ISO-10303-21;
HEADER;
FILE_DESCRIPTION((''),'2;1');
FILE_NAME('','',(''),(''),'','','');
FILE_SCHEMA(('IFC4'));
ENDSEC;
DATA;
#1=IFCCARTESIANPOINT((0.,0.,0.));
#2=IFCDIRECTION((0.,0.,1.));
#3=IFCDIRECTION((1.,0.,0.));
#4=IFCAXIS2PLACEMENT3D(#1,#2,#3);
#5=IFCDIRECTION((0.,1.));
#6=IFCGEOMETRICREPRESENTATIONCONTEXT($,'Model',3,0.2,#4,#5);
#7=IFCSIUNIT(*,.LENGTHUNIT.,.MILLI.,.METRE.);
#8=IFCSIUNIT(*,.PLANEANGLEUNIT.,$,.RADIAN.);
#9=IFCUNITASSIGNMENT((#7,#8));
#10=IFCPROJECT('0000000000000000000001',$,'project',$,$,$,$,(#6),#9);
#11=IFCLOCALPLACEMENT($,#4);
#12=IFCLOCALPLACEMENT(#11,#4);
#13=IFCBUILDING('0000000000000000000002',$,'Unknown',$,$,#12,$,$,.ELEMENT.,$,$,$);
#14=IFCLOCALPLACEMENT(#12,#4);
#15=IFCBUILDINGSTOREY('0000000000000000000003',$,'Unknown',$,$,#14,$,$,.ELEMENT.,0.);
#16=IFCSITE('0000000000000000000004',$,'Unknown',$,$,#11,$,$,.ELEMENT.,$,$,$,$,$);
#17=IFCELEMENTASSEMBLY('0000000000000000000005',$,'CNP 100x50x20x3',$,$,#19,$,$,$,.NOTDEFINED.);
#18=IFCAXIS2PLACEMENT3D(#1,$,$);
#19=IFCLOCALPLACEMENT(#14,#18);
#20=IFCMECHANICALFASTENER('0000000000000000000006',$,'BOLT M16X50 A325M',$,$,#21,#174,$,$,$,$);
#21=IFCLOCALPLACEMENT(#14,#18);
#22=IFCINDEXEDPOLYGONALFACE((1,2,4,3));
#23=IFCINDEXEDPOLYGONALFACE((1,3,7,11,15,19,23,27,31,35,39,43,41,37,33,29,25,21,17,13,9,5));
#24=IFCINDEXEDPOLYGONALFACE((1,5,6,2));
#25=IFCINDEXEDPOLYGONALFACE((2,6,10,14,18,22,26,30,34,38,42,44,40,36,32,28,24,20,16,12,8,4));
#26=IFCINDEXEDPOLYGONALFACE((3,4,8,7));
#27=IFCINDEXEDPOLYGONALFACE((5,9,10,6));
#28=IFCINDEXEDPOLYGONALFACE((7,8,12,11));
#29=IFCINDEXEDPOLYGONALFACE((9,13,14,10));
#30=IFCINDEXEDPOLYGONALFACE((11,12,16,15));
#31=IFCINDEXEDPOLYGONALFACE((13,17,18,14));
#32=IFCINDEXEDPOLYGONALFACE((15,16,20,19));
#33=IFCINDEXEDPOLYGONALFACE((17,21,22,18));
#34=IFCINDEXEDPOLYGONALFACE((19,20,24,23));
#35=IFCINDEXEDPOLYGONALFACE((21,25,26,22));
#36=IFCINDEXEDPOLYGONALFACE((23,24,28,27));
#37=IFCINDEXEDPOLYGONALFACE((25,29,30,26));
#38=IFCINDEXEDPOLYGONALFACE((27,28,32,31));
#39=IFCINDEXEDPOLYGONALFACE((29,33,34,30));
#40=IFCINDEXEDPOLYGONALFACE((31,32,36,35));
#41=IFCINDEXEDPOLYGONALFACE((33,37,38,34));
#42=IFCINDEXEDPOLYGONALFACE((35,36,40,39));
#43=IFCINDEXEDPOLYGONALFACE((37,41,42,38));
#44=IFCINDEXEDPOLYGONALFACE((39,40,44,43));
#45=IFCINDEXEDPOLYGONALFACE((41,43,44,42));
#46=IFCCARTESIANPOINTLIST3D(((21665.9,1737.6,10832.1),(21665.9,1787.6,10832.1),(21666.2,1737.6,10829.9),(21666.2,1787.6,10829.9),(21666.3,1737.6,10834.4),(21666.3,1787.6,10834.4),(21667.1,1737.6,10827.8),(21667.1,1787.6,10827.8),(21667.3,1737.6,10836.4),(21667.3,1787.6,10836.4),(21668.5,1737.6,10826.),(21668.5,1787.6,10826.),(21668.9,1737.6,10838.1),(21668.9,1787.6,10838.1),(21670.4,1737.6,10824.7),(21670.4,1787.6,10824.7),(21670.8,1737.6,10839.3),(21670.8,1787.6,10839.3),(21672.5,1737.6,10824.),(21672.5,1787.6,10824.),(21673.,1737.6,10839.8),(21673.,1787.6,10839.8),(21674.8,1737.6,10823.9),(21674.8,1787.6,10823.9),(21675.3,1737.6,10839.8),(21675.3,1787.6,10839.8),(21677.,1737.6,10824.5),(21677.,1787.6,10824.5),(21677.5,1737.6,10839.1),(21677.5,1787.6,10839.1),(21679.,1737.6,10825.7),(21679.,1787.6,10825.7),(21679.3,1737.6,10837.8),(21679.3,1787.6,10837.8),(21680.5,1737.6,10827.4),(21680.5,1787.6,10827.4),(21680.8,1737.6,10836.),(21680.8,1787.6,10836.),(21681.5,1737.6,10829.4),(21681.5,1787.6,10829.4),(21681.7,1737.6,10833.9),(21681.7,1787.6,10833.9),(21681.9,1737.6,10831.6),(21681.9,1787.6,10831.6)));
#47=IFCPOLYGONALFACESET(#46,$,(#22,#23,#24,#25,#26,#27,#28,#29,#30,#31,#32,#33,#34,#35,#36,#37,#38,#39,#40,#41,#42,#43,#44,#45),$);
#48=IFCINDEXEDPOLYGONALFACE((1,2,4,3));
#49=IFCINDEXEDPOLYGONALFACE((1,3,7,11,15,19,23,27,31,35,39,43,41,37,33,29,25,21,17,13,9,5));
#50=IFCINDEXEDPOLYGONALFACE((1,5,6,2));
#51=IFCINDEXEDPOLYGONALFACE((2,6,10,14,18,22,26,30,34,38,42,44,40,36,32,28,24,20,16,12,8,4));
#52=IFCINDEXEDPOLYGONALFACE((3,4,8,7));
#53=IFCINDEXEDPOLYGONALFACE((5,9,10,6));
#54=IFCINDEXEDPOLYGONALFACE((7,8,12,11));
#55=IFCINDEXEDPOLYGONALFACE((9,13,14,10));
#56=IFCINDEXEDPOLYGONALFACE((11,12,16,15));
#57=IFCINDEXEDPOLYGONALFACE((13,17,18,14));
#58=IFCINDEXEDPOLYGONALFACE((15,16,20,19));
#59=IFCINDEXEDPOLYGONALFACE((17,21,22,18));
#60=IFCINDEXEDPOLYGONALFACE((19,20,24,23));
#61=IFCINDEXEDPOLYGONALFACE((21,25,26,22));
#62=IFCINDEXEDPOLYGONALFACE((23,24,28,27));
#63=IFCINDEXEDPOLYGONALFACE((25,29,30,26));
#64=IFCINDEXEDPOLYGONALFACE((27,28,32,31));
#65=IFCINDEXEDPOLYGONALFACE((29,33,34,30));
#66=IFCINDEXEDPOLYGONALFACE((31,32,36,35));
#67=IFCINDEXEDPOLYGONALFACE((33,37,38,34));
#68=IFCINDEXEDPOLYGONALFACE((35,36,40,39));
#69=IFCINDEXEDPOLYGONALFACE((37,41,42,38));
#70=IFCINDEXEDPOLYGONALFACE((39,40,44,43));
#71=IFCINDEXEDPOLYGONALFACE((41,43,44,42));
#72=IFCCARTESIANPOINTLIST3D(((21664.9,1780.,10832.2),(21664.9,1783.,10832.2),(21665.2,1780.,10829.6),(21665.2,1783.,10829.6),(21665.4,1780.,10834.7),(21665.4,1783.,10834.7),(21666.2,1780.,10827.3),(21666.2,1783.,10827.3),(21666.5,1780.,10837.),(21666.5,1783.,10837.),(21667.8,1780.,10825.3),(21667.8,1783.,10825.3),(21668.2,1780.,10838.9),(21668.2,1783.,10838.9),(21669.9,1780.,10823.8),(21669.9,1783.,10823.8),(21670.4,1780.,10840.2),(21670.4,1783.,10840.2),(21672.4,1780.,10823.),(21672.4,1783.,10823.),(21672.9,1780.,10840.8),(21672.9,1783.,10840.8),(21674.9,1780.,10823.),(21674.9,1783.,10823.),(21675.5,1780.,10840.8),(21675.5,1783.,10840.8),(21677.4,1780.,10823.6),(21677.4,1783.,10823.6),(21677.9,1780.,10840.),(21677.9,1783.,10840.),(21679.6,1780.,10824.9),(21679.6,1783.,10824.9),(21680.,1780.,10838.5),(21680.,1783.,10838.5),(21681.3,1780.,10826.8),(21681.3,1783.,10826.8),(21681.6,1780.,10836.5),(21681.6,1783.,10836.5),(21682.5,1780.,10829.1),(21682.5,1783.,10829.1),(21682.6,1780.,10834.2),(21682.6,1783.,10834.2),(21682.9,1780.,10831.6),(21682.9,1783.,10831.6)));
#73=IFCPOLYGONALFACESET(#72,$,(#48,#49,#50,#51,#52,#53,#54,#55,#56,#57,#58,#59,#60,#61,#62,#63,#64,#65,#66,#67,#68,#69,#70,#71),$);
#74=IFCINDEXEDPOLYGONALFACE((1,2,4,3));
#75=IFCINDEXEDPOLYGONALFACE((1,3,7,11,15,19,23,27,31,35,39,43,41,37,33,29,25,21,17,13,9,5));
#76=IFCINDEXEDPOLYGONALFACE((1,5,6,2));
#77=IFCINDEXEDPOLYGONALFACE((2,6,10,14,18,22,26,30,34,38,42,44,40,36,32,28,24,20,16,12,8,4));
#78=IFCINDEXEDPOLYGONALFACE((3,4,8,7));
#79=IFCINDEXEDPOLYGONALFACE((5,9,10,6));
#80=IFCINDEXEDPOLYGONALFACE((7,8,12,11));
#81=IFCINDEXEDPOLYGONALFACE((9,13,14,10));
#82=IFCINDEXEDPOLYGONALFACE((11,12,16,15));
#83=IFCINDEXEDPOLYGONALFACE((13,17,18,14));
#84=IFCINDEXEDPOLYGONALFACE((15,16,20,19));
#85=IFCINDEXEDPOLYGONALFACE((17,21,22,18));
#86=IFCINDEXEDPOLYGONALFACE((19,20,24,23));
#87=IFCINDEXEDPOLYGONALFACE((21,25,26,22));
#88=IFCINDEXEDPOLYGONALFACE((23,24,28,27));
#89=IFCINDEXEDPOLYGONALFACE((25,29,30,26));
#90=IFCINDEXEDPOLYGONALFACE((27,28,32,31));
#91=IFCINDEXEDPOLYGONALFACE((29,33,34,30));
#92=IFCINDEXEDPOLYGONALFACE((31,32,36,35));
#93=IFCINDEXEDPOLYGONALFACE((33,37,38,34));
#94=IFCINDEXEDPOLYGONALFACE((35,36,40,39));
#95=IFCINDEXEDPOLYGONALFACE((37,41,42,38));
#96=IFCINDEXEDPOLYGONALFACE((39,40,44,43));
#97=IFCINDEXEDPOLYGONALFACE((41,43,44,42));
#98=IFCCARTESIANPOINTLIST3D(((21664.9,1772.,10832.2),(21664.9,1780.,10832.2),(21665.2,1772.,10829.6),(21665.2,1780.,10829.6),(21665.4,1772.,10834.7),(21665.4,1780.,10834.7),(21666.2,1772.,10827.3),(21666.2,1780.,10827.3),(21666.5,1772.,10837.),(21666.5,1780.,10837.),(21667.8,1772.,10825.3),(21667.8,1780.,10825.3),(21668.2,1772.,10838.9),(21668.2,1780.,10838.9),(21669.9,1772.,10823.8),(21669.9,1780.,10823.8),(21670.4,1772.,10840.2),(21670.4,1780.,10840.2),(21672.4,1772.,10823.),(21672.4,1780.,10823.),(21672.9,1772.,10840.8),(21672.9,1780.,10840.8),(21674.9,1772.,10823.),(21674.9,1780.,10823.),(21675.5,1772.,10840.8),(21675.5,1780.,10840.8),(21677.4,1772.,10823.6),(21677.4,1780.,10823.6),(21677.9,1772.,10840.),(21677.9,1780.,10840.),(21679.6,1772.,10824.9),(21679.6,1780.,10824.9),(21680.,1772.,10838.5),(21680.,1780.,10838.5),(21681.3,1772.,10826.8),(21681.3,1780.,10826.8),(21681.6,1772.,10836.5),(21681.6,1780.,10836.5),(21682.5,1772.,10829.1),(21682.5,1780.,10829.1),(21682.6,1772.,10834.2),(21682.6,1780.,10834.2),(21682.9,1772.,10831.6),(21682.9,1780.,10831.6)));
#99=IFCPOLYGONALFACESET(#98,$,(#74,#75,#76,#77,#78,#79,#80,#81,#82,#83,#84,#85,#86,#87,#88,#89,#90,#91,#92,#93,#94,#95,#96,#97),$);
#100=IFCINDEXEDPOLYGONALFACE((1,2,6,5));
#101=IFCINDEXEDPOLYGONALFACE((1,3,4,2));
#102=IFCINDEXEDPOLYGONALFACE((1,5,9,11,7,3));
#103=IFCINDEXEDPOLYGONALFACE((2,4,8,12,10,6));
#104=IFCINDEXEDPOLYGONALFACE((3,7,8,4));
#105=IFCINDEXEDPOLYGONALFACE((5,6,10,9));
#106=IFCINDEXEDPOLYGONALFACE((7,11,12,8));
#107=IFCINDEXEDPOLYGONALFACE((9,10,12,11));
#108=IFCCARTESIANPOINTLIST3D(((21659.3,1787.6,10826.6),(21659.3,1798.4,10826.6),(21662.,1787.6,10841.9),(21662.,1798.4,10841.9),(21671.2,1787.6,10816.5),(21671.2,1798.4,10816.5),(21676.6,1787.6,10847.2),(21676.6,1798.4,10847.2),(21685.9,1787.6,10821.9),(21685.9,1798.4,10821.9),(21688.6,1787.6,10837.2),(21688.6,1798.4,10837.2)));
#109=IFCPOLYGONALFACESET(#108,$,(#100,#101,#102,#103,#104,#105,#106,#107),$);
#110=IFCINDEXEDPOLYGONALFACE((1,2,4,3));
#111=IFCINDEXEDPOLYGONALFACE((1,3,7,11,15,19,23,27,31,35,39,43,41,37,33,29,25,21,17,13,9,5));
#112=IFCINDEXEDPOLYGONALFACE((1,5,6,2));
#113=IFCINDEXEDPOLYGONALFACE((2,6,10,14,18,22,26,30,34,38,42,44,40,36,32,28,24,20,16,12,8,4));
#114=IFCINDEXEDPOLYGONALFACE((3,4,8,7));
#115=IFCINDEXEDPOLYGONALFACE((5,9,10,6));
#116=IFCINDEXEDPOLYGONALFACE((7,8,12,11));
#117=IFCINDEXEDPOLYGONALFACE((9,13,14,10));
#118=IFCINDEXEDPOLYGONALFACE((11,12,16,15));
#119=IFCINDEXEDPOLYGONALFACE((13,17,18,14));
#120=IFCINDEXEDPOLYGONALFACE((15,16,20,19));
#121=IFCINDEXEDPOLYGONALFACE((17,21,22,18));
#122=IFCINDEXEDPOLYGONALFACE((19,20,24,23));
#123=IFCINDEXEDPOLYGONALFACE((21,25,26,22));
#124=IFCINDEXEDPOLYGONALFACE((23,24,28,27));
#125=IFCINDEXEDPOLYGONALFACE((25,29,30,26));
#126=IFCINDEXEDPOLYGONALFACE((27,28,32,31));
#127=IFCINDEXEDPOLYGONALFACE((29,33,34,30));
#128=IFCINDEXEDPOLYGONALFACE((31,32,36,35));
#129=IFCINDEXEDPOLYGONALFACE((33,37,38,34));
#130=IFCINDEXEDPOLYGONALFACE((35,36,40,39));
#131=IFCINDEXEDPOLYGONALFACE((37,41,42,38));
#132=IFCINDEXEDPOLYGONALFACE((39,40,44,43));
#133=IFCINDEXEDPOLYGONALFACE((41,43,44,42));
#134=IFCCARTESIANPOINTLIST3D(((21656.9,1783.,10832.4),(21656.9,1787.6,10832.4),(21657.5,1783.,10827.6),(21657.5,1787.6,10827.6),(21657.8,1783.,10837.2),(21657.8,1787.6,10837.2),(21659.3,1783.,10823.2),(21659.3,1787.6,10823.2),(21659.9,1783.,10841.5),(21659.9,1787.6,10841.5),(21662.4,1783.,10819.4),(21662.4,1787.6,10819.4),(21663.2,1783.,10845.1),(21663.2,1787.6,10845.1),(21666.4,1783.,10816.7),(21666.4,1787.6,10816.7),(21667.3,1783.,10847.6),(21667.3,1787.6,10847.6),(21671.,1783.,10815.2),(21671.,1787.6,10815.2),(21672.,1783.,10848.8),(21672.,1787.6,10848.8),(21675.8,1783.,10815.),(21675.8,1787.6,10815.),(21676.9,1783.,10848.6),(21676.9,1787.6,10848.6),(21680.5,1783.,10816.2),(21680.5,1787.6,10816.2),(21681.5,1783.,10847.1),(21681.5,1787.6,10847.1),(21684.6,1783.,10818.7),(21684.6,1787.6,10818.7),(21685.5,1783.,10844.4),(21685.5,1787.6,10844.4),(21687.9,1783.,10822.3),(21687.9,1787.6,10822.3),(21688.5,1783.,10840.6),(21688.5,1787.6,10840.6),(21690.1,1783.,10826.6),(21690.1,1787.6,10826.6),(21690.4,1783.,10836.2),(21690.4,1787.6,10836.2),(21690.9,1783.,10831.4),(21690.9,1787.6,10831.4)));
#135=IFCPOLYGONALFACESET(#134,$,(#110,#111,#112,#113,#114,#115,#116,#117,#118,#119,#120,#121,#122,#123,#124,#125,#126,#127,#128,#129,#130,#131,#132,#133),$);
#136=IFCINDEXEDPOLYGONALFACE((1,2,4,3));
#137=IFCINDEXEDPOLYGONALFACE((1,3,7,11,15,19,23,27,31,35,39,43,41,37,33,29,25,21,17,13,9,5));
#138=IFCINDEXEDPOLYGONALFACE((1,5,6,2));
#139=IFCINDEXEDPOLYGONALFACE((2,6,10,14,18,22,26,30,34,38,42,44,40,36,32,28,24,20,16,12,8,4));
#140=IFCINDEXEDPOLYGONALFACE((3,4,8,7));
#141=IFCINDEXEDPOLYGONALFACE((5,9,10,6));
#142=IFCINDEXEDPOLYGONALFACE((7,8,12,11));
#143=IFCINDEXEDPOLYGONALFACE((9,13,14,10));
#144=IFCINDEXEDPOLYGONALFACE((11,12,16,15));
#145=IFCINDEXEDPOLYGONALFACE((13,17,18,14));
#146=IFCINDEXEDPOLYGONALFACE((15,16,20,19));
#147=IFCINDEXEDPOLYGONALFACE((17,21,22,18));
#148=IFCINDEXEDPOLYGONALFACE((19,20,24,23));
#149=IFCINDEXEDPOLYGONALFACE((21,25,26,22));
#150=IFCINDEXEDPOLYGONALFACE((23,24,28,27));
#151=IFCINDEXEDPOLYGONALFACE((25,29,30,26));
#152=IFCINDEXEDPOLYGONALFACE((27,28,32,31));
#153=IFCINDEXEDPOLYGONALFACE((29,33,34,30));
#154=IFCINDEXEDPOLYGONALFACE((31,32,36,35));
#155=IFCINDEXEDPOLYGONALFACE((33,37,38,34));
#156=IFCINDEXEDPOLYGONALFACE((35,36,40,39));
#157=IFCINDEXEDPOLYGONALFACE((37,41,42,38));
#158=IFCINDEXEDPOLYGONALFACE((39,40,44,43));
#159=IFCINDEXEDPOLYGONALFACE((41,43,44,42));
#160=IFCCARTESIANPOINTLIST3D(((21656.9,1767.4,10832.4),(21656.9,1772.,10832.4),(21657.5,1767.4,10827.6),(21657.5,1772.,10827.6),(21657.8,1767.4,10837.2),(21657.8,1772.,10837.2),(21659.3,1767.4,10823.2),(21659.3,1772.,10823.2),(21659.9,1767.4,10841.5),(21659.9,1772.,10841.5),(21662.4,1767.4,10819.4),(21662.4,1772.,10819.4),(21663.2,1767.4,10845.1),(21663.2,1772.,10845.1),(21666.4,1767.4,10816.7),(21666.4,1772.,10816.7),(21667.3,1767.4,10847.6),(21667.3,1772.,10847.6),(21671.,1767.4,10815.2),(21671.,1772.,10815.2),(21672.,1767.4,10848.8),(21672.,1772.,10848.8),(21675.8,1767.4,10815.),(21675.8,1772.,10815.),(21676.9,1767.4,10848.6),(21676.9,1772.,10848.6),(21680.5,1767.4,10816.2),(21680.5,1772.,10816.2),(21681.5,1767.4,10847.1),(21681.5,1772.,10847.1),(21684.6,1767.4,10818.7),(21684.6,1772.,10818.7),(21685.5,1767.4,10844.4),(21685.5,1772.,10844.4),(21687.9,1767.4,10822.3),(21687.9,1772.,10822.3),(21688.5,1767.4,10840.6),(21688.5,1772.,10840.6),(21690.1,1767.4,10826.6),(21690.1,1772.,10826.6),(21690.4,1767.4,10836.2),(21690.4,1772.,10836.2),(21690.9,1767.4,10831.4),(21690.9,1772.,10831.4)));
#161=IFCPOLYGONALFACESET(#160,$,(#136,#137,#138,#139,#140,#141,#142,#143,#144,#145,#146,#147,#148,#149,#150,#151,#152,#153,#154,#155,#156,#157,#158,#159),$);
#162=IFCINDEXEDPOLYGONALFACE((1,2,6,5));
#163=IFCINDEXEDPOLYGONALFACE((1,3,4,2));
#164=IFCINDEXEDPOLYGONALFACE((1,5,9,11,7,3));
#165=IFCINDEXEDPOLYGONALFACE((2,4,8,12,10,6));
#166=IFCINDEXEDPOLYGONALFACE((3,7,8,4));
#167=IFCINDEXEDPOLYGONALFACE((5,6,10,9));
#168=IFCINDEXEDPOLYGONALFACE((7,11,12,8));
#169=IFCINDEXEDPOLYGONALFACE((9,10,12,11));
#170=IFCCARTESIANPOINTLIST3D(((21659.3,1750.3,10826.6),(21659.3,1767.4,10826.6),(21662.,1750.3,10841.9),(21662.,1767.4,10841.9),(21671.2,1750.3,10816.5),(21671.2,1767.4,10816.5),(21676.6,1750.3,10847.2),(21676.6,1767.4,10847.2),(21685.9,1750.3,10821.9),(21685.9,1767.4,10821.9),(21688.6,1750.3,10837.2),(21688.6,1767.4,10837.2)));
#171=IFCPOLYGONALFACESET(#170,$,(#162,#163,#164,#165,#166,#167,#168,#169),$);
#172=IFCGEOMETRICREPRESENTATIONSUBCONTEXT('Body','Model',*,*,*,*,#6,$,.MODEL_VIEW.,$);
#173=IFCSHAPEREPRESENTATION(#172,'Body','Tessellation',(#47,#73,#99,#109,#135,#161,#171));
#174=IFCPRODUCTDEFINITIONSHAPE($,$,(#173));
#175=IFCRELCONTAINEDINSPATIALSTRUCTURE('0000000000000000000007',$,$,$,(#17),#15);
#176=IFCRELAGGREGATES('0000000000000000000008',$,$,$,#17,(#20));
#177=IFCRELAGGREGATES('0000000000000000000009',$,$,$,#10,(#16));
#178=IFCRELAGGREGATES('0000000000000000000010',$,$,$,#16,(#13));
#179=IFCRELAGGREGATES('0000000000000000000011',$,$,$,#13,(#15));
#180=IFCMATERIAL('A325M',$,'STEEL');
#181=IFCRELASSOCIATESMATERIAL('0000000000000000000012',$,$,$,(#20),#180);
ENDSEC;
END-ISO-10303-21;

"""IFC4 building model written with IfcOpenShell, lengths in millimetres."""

from ifc_helpers import new_model, si_unit, direction, frame, origin_with_axes, place, context, subcontext, project, spatial, line, arc, indexed_curve, outline, extrude, source, transform, mapped, material, element, aggregate, save


model = new_model("IFC4")

# Units and contexts
model_context = context("Model", 3, precision=0.2, world=origin_with_axes(), true_north=direction((0.0, 1.0)))
body_context = subcontext(model_context, "Body", "Model", "MODEL_VIEW")
ifc_project = project(units=[si_unit("LENGTHUNIT", "METRE", prefix="MILLI"), si_unit("PLANEANGLEUNIT", "RADIAN")], contexts=[model_context])

# Site, building, storey
site_placement = place(None, origin_with_axes())
site = spatial("IfcSite", under=ifc_project, at=site_placement, Name="Unknown", CompositionType="ELEMENT")
building_placement = place(site_placement, origin_with_axes())
building = spatial("IfcBuilding", under=site, at=building_placement, Name="Unknown", CompositionType="ELEMENT")
storey_placement = place(building_placement, origin_with_axes())
storey = spatial("IfcBuildingStorey", under=building, at=storey_placement, Name="Unknown", CompositionType="ELEMENT", Elevation=0.0)

# Shared definitions
ifc_material_1 = material(Name="A325M", Category="STEEL")
shared_shape = source(origin_with_axes(), body_context, "Body", "SweptSolid", [
    extrude(outline(indexed_curve([(8.0, 0.0), (0.0, 8.0), (-8.0, 0.0), (0.0, -8.0)], segments=[arc(1, 2, 3), arc(3, 4, 1)])), frame((0.0, 0.0, 15.6), z_axis=(0.0, 0.0, -1.0), x_axis=(0.0, 1.0, 0.0)), (0.0, 0.0, 1.0), 50.0),
    extrude(outline(indexed_curve([(9.0, 0.0), (0.0, 9.0), (-9.0, 0.0), (0.0, -9.0)], segments=[arc(1, 2, 3), arc(3, 4, 1)])), frame((0.0, 0.0, 11.0), z_axis=(0.0, 0.0, -1.0), x_axis=(0.0, 1.0, 0.0)), (0.0, 0.0, 1.0), 3.0),
    extrude(outline(indexed_curve([(9.0, 0.0), (0.0, 9.0), (-9.0, 0.0), (0.0, -9.0)], segments=[arc(1, 2, 3), arc(3, 4, 1)])), frame((0.0, 0.0, 8.0), z_axis=(0.0, 0.0, -1.0), x_axis=(0.0, 1.0, 0.0)), (0.0, 0.0, 1.0), 8.0),
    extrude(outline(indexed_curve([(15.6, 0.0), (7.8, 13.5), (-7.8, 13.5), (-15.6, 0.0), (-7.8, -13.5), (7.8, -13.5)], segments=[line(1, 2, 3, 4, 5, 6, 1)])), frame((0.0, 0.0, 26.4), z_axis=(0.0, 0.0, -1.0), x_axis=(0.0, 1.0, 0.0)), (0.0, 0.0, 1.0), 10.8),
    extrude(outline(indexed_curve([(17.0, 0.0), (0.0, 17.0), (-17.0, 0.0), (0.0, -17.0)], segments=[arc(1, 2, 3), arc(3, 4, 1)])), frame((0.0, 0.0, 15.6), z_axis=(0.0, 0.0, -1.0), x_axis=(0.0, 1.0, 0.0)), (0.0, 0.0, 1.0), 4.6),
    extrude(outline(indexed_curve([(17.0, 0.0), (0.0, 17.0), (-17.0, 0.0), (0.0, -17.0)], segments=[arc(1, 2, 3), arc(3, 4, 1)])), frame((0.0, 0.0, 0.0), z_axis=(0.0, 0.0, -1.0), x_axis=(0.0, 1.0, 0.0)), (0.0, 0.0, 1.0), 4.6),
    extrude(outline(indexed_curve([(15.6, 0.0), (7.8, 13.5), (-7.8, 13.5), (-15.6, 0.0), (-7.8, -13.5), (7.8, -13.5)], segments=[line(1, 2, 3, 4, 5, 6, 1)])), frame((0.0, 0.0, -4.6), z_axis=(0.0, 0.0, -1.0), x_axis=(0.0, 1.0, 0.0)), (0.0, 0.0, 1.0), 17.1),
])

# Element assembly, mechanical fastener
assembly_1_placement = place(storey_placement, frame((25552.5, 1805.0, 10153.1), z_axis=(0.173648, 0.0, 0.984808), x_axis=(-0.984808, 0.0, 0.173648)))
assembly_1 = element("IfcElementAssembly", 1, at=assembly_1_placement, inside=storey, Name="CNP 100x50x20x3", PredefinedType="NOTDEFINED")
mechanical_fastener_1_placement = place(assembly_1_placement, frame((3937.5, 33.0, -5.0), z_axis=(0.0, -1.0, 0.0), x_axis=(-1.0, 0.0, 0.0)))
mechanical_fastener_1 = element("IfcMechanicalFastener", 2, at=mechanical_fastener_1_placement, material=ifc_material_1, Name="BOLT M16X50 A325M", context=body_context, shape_type="MappedRepresentation", body=[
    mapped(shared_shape, transform((0.0, 0.0, 0.0))),
])
aggregate(assembly_1, [mechanical_fastener_1])

save(model, "model.ifc")
